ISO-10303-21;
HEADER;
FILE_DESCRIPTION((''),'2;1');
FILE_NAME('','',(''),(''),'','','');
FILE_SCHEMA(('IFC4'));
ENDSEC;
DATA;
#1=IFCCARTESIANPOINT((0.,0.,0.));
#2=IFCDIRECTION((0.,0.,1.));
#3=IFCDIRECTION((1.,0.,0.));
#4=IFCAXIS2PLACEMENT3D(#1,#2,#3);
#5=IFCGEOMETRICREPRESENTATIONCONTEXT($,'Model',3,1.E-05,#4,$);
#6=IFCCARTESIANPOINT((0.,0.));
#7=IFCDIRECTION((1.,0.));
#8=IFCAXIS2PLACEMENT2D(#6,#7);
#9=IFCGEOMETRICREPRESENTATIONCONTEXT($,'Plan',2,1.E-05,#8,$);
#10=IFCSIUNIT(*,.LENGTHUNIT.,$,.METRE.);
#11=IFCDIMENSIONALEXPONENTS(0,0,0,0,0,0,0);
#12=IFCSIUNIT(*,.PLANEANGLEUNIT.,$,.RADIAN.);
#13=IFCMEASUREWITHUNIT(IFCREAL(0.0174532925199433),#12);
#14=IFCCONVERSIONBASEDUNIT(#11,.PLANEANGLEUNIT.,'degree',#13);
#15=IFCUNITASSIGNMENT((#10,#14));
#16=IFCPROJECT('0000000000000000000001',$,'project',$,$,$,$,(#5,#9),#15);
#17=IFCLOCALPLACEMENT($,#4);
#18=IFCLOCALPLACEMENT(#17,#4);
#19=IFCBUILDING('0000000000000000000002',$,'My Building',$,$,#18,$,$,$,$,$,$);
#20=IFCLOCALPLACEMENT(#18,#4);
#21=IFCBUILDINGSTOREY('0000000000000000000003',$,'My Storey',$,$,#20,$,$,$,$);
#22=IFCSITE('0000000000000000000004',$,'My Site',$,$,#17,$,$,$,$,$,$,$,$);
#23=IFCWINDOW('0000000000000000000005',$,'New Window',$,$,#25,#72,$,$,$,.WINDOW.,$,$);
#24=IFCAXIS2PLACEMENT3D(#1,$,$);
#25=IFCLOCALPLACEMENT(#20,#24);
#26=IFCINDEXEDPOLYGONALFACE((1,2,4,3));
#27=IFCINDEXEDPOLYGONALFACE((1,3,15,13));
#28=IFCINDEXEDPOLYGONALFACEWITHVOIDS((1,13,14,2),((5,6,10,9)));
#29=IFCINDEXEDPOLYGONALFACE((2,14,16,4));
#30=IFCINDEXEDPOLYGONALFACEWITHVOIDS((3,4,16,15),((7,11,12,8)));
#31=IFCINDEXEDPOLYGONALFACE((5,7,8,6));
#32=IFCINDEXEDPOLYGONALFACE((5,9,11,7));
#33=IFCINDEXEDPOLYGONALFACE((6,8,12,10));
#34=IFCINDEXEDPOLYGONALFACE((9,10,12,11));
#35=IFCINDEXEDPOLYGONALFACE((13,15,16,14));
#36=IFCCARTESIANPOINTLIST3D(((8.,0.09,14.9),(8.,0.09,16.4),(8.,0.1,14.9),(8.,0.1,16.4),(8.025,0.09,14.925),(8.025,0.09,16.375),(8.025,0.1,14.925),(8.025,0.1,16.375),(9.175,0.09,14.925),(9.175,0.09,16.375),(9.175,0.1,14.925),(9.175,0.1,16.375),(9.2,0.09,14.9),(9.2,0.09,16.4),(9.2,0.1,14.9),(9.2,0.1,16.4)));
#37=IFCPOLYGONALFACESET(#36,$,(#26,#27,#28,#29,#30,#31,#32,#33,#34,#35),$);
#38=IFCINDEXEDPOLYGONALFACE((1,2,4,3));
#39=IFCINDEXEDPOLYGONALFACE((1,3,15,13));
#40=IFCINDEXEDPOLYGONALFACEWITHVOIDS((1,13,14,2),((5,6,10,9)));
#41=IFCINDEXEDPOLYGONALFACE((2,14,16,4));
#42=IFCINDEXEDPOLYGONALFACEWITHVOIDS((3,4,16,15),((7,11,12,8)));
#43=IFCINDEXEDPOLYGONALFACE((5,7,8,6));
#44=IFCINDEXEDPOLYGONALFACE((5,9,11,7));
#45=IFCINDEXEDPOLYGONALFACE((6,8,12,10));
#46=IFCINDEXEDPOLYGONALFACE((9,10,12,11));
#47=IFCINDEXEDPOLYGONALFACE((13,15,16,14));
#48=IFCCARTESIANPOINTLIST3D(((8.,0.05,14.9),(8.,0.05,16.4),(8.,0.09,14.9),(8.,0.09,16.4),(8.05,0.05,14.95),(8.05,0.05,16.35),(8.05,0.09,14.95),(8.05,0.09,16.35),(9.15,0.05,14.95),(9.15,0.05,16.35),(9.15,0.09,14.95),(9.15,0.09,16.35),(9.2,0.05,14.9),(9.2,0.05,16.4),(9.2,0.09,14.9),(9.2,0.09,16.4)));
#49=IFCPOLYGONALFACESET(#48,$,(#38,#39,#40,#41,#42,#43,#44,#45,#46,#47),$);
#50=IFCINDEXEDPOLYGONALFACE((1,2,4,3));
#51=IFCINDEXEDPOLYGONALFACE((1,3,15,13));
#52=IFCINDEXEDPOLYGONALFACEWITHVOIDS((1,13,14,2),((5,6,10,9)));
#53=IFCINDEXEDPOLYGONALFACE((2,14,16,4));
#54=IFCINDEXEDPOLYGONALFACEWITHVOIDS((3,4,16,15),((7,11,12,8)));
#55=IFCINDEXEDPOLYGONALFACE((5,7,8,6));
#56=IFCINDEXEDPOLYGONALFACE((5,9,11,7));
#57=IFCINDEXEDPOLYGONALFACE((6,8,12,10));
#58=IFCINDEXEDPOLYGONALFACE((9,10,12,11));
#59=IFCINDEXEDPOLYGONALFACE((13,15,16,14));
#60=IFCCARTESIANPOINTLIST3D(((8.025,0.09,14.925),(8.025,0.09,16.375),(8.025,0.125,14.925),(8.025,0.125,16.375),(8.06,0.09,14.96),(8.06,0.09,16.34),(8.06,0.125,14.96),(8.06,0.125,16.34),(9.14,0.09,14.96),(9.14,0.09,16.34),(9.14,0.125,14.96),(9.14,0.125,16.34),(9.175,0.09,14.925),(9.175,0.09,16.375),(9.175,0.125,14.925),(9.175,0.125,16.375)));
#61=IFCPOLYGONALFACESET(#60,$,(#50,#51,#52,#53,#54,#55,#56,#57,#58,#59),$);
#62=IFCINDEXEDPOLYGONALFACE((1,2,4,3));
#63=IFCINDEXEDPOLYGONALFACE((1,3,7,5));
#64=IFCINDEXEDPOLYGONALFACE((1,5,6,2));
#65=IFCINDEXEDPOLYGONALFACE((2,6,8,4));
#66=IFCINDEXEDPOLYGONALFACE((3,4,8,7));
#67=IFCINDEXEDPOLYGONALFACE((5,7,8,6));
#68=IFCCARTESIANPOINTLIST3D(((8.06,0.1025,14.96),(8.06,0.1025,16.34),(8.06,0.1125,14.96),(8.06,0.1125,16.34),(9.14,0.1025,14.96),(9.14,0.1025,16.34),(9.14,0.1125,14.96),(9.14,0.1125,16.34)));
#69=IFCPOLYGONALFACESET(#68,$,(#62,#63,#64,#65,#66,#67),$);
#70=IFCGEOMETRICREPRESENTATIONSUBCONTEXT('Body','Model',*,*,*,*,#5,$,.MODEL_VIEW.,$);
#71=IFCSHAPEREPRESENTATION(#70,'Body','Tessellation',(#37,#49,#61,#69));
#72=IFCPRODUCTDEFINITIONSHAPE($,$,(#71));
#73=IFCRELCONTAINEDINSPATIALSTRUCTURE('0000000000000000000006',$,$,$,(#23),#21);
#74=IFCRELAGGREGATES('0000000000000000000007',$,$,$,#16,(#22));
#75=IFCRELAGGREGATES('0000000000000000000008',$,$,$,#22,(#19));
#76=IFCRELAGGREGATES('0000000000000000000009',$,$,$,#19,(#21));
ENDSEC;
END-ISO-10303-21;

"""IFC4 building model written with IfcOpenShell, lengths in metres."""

from ifc_helpers import new_model, entity, si_unit, converted_unit, frame, origin_with_axes, origin_2d_with_axis, place, context, subcontext, project, spatial, line, indexed_curve, outline, extrude, element, save


model = new_model("IFC4")

# Units and contexts
model_context = context("Model", 3, precision=1e-05, world=origin_with_axes())
plan_context = context("Plan", 2, precision=1e-05, world=origin_2d_with_axis())
body_context = subcontext(model_context, "Body", "Model", "MODEL_VIEW")
ifc_project = project(units=[si_unit("LENGTHUNIT", "METRE"), converted_unit("PLANEANGLEUNIT", "degree", entity("IfcReal", 0.0174532925199433), si_unit("PLANEANGLEUNIT", "RADIAN"), dimensions=[0, 0, 0, 0, 0, 0, 0])], contexts=[model_context, plan_context])

# Site, building, storey
site_placement = place(None, origin_with_axes())
site = spatial("IfcSite", under=ifc_project, at=site_placement, Name="My Site")
building_placement = place(site_placement, origin_with_axes())
building = spatial("IfcBuilding", under=site, at=building_placement, Name="My Building")
storey_placement = place(building_placement, origin_with_axes())
storey = spatial("IfcBuildingStorey", under=building, at=storey_placement, Name="My Storey")

# Window
for number, where, z_axis, x_axis, name in (
    (1, (8.0, 0.0, 14.9), (0.0, 0.0, 1.0), (1.0, 0.0, 0.0), "New Window"),
):
    element("IfcWindow", number, at=place(storey_placement, frame(where, z_axis=z_axis, x_axis=x_axis)), inside=storey, Name=name, PredefinedType="WINDOW", context=body_context, shape_type="SweptSolid", body=[
        extrude(outline(indexed_curve([(0.0, 0.0), (1.2, 0.0), (1.2, 1.5), (0.0, 1.5)], segments=[line(1, 2, 3, 4, 1)]), holes=[indexed_curve([(0.025, 0.025), (1.175, 0.025), (1.175, 1.475), (0.025, 1.475)], segments=[line(1, 2, 3, 4, 1)])]), frame((0.0, 0.09, 0.0), z_axis=(0.0, -1.0, 0.0), x_axis=(1.0, 0.0, 0.0)), (0.0, 0.0, -1.0), 0.01),
        extrude(outline(indexed_curve([(0.0, 0.0), (1.2, 0.0), (1.2, 1.5), (0.0, 1.5)], segments=[line(1, 2, 3, 4, 1)]), holes=[indexed_curve([(0.05, 0.05), (1.15, 0.05), (1.15, 1.45), (0.05, 1.45)], segments=[line(1, 2, 3, 4, 1)])]), frame((0.0, 0.05, 0.0), z_axis=(0.0, -1.0, 0.0), x_axis=(1.0, 0.0, 0.0)), (0.0, 0.0, -1.0), 0.04),
        extrude(outline(indexed_curve([(0.0, 0.0), (1.15, 0.0), (1.15, 1.45), (0.0, 1.45)], segments=[line(1, 2, 3, 4, 1)]), holes=[indexed_curve([(0.035, 0.035), (1.115, 0.035), (1.115, 1.415), (0.035, 1.415)], segments=[line(1, 2, 3, 4, 1)])]), frame((0.025, 0.09, 0.025), z_axis=(0.0, -1.0, 0.0), x_axis=(1.0, 0.0, 0.0)), (0.0, 0.0, -1.0), 0.035),
        extrude(outline(indexed_curve([(0.035, 0.035), (1.115, 0.035), (1.115, 1.415), (0.035, 1.415)], segments=[line(1, 2, 3, 4, 1)])), frame((0.025, 0.1025, 0.025), z_axis=(0.0, -1.0, 0.0), x_axis=(1.0, 0.0, 0.0)), (0.0, 0.0, -1.0), 0.01),
    ])

save(model, "model.ifc")
